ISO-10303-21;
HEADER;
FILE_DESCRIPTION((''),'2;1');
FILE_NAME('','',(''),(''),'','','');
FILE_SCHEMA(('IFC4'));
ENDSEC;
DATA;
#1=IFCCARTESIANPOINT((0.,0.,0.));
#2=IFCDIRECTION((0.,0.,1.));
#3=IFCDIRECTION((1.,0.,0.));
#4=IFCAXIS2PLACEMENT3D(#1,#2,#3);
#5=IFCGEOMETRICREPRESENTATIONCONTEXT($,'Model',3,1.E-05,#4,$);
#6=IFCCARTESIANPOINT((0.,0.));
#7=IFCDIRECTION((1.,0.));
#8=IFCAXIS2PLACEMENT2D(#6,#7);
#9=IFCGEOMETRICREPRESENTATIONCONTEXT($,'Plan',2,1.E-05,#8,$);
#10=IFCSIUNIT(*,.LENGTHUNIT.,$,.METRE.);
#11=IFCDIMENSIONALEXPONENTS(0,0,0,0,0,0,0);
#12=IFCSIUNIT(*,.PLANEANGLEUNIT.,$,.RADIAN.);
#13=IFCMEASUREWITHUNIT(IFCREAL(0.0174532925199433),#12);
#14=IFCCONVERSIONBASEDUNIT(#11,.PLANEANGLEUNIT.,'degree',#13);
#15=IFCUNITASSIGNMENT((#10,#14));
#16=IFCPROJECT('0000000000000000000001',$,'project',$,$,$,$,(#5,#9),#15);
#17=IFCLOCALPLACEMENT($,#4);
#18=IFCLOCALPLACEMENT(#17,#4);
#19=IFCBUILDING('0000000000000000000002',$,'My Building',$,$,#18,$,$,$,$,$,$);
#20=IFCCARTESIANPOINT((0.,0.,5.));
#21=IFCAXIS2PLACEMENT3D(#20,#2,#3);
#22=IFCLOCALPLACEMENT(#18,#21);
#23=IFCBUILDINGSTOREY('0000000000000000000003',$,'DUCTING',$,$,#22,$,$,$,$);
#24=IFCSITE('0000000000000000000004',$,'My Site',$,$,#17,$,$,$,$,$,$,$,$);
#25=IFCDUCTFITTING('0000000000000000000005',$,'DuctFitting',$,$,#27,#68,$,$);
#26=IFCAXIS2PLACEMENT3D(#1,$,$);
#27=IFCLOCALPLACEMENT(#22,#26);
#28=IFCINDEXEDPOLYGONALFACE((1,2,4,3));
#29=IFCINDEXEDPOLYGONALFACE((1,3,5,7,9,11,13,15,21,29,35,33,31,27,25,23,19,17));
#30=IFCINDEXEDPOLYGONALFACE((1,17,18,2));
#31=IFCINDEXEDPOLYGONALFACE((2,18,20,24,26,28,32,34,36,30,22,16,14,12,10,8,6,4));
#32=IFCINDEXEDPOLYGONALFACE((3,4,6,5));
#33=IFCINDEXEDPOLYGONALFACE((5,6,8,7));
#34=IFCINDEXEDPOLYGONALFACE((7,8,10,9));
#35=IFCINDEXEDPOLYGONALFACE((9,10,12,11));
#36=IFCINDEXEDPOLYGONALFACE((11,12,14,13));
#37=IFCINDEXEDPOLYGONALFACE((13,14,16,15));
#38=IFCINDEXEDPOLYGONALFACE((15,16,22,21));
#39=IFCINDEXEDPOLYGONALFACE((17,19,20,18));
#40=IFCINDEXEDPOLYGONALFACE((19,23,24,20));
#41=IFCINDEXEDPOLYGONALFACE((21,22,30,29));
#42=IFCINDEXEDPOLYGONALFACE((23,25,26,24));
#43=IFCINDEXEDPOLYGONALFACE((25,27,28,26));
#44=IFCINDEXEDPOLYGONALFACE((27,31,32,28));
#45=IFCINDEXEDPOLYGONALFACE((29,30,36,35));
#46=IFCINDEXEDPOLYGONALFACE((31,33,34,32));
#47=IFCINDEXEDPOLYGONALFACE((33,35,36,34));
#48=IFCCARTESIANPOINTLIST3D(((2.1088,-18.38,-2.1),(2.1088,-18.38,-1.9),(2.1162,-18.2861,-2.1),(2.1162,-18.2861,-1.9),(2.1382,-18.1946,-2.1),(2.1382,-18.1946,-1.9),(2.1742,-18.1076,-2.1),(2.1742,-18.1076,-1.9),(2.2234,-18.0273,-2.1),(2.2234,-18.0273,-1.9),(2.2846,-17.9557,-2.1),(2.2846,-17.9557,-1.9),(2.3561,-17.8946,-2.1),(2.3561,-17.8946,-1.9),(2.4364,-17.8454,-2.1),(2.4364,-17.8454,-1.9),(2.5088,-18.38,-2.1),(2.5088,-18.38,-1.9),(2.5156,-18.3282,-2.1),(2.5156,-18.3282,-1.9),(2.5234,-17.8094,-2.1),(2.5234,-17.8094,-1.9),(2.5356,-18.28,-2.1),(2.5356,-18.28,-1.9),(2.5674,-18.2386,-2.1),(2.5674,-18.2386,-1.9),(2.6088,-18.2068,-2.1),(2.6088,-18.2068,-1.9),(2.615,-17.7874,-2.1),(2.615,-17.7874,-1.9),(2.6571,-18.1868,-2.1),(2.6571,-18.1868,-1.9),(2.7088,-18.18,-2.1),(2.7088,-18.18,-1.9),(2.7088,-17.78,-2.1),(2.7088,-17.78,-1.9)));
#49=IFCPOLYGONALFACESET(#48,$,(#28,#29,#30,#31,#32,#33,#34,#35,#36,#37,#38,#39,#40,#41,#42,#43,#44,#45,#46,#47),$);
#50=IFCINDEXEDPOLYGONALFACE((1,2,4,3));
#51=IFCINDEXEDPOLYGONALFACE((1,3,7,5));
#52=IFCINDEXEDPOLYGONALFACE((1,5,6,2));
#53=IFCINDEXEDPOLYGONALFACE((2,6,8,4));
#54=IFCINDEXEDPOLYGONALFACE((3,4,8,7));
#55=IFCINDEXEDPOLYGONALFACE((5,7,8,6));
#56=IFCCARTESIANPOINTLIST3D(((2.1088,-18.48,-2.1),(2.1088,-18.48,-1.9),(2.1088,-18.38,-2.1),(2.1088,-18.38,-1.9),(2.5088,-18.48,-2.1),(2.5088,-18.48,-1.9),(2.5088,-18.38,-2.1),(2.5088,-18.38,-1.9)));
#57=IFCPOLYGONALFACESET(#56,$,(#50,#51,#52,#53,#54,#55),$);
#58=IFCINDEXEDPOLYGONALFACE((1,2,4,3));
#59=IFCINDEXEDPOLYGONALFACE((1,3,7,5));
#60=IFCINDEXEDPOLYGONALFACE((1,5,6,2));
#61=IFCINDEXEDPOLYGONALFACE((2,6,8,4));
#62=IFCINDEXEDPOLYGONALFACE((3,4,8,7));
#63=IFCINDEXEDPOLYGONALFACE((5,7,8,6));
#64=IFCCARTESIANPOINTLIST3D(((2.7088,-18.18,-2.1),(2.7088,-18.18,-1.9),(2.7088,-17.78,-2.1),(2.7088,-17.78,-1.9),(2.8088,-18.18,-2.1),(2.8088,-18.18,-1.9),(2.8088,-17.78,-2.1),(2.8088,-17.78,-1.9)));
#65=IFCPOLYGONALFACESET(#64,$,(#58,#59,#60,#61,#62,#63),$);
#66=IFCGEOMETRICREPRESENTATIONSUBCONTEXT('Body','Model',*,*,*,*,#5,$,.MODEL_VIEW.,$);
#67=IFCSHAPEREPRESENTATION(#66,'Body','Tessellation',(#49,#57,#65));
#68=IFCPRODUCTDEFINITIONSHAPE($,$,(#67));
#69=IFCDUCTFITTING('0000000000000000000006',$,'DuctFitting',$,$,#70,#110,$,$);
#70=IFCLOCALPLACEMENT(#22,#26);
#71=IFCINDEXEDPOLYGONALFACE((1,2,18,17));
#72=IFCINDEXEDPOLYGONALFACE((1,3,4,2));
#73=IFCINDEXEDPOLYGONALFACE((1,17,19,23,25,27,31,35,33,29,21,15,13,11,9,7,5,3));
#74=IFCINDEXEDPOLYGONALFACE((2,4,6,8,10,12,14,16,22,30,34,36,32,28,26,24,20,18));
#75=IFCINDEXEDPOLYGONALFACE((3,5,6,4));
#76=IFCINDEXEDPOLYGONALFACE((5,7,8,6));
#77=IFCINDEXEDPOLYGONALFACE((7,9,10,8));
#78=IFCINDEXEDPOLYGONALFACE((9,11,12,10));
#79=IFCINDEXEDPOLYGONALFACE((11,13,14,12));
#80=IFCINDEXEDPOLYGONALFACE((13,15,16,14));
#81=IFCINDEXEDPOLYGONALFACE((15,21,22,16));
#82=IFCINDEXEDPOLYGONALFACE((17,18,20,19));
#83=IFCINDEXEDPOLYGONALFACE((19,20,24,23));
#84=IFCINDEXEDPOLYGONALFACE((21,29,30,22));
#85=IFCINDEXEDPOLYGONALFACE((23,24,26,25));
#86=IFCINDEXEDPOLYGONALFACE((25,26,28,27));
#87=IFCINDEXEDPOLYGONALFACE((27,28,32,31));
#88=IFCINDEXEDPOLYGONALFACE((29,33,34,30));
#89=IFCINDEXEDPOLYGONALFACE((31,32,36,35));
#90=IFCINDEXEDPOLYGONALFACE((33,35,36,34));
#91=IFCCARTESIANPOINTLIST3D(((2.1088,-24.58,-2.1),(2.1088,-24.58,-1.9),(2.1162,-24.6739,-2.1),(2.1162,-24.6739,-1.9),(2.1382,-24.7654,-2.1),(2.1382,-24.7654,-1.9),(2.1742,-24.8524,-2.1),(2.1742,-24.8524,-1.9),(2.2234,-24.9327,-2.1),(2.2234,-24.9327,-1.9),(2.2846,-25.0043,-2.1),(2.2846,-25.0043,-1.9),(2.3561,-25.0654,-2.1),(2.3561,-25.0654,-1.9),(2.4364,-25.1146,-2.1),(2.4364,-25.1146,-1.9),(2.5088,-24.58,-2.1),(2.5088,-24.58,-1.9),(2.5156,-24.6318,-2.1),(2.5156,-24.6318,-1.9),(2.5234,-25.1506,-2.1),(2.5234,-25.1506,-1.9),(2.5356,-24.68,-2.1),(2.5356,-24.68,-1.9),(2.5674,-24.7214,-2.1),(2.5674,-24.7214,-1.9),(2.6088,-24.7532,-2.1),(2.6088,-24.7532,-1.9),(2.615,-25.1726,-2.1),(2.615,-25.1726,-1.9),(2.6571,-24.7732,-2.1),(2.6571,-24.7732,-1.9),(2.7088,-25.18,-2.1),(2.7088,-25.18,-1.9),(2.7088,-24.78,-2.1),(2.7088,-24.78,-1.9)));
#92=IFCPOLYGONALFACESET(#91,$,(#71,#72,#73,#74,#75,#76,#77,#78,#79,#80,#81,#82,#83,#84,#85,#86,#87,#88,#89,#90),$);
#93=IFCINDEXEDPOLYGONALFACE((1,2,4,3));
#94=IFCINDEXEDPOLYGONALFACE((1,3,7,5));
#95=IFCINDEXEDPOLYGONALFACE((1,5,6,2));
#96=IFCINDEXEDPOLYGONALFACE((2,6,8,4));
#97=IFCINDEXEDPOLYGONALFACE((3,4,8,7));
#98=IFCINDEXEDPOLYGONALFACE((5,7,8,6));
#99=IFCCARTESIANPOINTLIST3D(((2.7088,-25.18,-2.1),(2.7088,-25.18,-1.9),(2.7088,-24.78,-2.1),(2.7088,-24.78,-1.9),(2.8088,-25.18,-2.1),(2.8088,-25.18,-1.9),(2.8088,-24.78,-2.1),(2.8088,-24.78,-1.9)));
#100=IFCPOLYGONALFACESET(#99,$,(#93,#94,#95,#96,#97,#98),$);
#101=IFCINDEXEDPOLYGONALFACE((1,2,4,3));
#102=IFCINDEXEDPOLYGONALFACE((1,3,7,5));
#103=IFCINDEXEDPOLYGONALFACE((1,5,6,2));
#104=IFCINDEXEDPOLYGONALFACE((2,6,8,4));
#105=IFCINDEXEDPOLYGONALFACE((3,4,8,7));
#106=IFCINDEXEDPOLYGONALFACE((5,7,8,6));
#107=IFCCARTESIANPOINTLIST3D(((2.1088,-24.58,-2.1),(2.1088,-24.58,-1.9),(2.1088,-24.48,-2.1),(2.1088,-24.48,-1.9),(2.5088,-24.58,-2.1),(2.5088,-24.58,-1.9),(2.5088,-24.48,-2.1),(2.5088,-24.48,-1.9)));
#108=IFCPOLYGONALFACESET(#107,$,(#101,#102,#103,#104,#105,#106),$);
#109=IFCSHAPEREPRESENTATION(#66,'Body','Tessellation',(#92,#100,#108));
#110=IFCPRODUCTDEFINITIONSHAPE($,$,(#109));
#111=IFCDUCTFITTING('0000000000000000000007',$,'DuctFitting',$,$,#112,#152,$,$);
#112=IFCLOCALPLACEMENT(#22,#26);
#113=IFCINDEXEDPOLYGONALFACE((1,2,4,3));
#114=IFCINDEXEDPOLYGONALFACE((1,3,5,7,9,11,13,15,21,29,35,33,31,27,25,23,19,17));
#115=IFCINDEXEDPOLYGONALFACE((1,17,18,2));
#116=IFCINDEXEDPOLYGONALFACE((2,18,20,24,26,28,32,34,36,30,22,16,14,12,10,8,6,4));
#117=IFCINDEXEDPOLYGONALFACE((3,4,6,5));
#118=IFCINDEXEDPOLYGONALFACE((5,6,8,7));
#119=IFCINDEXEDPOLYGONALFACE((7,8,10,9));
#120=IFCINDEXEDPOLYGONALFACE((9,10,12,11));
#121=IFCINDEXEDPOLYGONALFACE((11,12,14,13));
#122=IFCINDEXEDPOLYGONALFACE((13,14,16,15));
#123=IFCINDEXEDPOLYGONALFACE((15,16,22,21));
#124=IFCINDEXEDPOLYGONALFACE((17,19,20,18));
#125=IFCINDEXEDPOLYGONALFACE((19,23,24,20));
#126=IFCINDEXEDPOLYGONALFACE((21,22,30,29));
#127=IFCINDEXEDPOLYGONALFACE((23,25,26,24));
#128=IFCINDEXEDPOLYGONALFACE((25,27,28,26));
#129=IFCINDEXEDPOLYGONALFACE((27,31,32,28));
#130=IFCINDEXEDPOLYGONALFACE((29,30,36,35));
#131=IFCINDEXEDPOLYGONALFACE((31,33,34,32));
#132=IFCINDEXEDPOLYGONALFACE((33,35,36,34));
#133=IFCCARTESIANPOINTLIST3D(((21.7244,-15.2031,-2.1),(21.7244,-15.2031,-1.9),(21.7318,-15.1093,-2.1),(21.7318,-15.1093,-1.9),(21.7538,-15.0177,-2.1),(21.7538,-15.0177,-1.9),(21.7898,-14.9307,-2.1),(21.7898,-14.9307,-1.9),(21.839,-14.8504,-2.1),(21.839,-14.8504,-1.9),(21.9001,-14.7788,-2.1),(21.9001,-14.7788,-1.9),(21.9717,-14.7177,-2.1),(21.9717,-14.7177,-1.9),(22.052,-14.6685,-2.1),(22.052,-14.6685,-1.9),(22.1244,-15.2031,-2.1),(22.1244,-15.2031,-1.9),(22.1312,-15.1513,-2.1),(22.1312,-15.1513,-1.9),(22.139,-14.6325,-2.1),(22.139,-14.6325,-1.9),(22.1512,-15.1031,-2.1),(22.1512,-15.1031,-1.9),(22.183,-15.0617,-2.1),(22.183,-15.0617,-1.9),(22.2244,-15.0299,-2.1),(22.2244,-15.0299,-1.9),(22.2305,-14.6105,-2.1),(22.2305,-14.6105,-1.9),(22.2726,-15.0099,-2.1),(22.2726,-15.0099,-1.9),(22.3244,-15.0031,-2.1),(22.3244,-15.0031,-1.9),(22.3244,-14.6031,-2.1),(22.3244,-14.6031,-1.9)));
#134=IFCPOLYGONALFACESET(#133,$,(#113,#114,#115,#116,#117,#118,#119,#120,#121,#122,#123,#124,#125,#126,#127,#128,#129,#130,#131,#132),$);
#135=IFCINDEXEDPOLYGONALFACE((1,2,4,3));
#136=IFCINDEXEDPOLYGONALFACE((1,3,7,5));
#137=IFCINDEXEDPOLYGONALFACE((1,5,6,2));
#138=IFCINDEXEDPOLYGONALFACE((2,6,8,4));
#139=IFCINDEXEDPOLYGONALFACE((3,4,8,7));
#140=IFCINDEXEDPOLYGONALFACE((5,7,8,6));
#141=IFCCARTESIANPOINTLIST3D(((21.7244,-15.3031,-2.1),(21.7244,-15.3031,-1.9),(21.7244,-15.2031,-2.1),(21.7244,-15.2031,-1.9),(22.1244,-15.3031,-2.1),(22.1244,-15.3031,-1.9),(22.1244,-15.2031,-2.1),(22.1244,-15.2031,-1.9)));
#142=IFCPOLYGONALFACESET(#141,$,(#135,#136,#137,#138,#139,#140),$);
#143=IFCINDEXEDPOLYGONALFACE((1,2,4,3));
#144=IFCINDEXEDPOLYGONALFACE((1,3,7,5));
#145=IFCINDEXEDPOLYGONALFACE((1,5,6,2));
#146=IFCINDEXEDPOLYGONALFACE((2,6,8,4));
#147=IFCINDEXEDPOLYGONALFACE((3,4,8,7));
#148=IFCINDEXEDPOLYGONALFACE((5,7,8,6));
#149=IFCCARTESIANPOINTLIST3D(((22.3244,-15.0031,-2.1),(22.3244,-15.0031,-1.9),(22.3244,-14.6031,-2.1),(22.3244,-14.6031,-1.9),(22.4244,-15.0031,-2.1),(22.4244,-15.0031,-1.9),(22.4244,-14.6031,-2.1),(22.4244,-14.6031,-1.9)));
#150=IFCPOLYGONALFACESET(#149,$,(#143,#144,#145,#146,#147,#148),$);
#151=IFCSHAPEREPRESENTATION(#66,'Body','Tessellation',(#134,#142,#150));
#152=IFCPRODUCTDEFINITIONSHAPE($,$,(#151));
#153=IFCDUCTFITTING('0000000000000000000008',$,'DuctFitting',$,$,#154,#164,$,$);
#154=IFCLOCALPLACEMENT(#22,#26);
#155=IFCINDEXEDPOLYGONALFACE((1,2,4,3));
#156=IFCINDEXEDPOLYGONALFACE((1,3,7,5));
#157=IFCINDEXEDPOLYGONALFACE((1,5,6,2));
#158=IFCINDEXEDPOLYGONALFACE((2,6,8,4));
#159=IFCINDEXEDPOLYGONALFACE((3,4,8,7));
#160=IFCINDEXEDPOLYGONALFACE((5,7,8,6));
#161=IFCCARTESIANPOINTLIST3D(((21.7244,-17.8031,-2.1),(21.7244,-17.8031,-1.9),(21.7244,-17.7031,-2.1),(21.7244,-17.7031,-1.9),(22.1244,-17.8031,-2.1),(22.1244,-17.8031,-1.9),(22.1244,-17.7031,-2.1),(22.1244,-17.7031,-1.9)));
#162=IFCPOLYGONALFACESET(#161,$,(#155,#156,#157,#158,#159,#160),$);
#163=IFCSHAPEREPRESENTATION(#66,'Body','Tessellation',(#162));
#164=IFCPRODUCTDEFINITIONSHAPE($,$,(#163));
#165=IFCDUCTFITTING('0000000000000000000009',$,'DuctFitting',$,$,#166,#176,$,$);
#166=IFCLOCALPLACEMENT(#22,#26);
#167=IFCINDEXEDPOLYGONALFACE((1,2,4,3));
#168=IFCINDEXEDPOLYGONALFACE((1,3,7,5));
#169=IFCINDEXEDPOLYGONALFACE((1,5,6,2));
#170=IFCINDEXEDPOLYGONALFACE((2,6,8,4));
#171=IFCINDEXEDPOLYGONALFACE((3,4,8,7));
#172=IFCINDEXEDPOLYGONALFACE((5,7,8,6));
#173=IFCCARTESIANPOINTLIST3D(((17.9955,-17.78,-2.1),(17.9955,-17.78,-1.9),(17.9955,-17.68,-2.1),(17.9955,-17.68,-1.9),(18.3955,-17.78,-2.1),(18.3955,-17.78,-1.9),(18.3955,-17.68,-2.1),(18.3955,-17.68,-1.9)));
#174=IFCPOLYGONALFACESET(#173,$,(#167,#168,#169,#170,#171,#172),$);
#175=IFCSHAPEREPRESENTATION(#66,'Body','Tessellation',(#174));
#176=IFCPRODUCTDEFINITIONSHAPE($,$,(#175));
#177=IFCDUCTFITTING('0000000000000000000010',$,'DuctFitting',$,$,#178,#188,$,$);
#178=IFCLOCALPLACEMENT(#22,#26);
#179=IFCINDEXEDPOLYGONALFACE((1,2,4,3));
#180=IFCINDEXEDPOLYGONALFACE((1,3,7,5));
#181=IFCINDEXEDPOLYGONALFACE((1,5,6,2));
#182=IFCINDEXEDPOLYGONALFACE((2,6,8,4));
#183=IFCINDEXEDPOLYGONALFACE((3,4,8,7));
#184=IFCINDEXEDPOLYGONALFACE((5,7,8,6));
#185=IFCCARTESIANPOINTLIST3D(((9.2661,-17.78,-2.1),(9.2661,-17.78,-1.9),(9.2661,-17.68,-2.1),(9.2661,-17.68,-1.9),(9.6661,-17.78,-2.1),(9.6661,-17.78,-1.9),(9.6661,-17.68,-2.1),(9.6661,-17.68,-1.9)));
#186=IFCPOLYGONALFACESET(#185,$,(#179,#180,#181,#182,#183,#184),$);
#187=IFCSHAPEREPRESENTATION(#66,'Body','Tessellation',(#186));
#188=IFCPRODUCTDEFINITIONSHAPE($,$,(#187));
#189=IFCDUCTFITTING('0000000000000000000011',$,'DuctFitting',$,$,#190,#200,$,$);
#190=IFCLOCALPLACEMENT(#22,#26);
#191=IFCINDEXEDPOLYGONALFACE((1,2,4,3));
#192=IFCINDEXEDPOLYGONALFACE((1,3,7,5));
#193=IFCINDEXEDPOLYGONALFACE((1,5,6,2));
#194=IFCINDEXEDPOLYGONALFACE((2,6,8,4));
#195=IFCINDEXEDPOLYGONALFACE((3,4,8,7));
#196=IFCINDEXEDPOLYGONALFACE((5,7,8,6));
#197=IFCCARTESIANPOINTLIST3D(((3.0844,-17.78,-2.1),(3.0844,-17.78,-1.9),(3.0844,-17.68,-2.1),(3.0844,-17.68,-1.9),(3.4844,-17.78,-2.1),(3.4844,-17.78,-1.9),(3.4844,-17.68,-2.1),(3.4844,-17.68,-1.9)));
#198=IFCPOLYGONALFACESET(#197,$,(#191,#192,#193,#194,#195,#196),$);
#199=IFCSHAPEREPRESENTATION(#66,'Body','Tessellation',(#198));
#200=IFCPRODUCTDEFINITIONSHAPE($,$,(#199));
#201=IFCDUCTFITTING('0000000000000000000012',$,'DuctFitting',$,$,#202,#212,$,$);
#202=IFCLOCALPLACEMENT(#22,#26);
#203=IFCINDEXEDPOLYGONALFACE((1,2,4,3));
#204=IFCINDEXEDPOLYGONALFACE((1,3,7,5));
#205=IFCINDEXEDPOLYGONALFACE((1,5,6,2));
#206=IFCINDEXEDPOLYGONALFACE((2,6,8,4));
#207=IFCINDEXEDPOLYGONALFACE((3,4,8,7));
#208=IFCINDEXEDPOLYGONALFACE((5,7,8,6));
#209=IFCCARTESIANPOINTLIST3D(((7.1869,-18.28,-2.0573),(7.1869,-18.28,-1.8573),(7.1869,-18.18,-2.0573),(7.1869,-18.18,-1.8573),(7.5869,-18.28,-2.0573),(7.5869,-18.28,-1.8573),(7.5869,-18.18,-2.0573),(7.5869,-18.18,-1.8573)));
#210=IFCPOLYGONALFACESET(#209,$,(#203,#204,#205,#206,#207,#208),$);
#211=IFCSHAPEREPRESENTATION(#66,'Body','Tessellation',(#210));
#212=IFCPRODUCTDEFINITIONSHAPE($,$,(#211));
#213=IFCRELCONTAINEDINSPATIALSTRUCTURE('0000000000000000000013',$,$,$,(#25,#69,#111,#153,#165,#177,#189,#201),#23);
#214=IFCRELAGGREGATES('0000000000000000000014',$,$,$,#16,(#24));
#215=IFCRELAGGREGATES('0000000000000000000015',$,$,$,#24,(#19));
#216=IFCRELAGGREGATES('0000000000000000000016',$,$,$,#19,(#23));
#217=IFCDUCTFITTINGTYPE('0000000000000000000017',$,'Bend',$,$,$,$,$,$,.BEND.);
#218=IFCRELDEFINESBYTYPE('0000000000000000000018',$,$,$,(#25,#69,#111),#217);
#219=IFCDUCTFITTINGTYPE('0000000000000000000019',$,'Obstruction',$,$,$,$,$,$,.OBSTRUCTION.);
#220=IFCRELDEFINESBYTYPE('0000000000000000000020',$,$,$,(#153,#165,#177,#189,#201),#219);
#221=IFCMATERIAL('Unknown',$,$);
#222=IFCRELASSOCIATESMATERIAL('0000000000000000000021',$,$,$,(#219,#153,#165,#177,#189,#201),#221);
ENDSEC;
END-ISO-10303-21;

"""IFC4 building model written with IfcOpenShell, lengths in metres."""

from ifc_helpers import new_model, entity, si_unit, converted_unit, frame, origin_with_axes, origin_2d_with_axis, place, context, subcontext, project, spatial, line, arc, indexed_curve, rectangle, outline, extrude, source, transform, mapped, material, material_profile, profile_set, profile_usage, type_object, type_shapes, element, save


model = new_model("IFC4")

# Units and contexts
model_context = context("Model", 3, precision=1e-05, world=origin_with_axes())
plan_context = context("Plan", 2, precision=1e-05, world=origin_2d_with_axis())
body_context = subcontext(model_context, "Body", "Model", "MODEL_VIEW")
ifc_project = project(units=[si_unit("LENGTHUNIT", "METRE"), converted_unit("PLANEANGLEUNIT", "degree", entity("IfcReal", 0.0174532925199433), si_unit("PLANEANGLEUNIT", "RADIAN"), dimensions=[0, 0, 0, 0, 0, 0, 0])], contexts=[model_context, plan_context])

# Site, building, storey
site_placement = place(None, origin_with_axes())
site = spatial("IfcSite", under=ifc_project, at=site_placement, Name="My Site")
building_placement = place(site_placement, origin_with_axes())
building = spatial("IfcBuilding", under=site, at=building_placement, Name="My Building")
storey_placement = place(building_placement, frame((0.0, 0.0, 5.0), z_axis=(0.0, 0.0, 1.0), x_axis=(1.0, 0.0, 0.0)))
storey = spatial("IfcBuildingStorey", under=building, at=storey_placement, Name="DUCTING")

# Shared definitions
ifc_material = material(Name="Unknown")

# Duct fittings
duct_fitting_type_1 = type_object("IfcDuctFittingType", Name="Bend", PredefinedType="BEND")
shared_shape = source(origin_with_axes(), body_context, "Body", "SweptSolid", [
    extrude(outline(indexed_curve([(0.2, 0.0), (0.2586, 0.1414), (0.4, 0.2), (0.4, 0.6), (-0.0243, 0.4243), (-0.2, 0.0)], segments=[arc(1, 2, 3), line(3, 4), arc(4, 5, 6), line(6, 1)])), frame((0.0, -0.1, 0.1), z_axis=(0.0, -1.0, 0.0), x_axis=(1.0, 0.0, 0.0)), (0.0, 0.0, -1.0), 0.2),
    extrude(rectangle(XDim=0.4, YDim=0.2), origin_with_axes(), (0.0, 0.0, 1.0), 0.1),
    extrude(rectangle(XDim=0.4, YDim=0.2), frame((0.4, 0.0, 0.5), z_axis=(1.0, 0.0, 0.000001), x_axis=(-0.000001, 0.0, 1.0)), (0.0, 0.0, 1.0), 0.1),
])
type_shapes(duct_fitting_type_1, [shared_shape])
for number, where, z_axis, x_axis, name in (
    (1, (2.3088, -18.48, -2.0), (0.0, 1.0, 0.0), (1.0, 0.0, 0.0), "DuctFitting"),
    (2, (2.8088, -24.98, -2.0), (-1.0, 0.0, 0.0), (0.0, 1.0, 0.0), "DuctFitting"),
    (3, (21.9244, -15.3031, -2.0), (0.0, 1.0, 0.000001), (1.0, 0.0, 0.0), "DuctFitting"),
):
    element("IfcDuctFitting", number, at=place(storey_placement, frame(where, z_axis=z_axis, x_axis=x_axis)), inside=storey, type_object=duct_fitting_type_1, Name=name, context=body_context, shape_type="MappedRepresentation", body=[
        mapped(shared_shape, transform((0.0, 0.0, 0.0), x_axis=(1.0, 0.0, 0.0), y_axis=(0.0, 1.0, 0.0), z_axis=(0.0, 0.0, 1.0), scale=1.0)),
    ])
ifc_material_profile_1 = material_profile(ifc_material, rectangle(XDim=0.4, YDim=0.2))
ifc_profile_set_1 = profile_set([ifc_material_profile_1])
ifc_profile_usage_1 = profile_usage(ifc_profile_set_1, cardinal=5)
duct_fitting_type_2 = type_object("IfcDuctFittingType", Name="Obstruction", PredefinedType="OBSTRUCTION", material=ifc_profile_set_1)
duct_fitting_1_placement = place(storey_placement, frame((21.9244, -17.8031, -2.0), z_axis=(0.0, 1.0, 0.000001), x_axis=(-1.0, 0.0, 0.0)))
element("IfcDuctFitting", 4, at=duct_fitting_1_placement, inside=storey, type_object=duct_fitting_type_2, material=ifc_profile_usage_1, Name="DuctFitting", context=body_context, shape_type="SweptSolid", body=[
    extrude(rectangle(XDim=0.4, YDim=0.2), origin_with_axes(), (0.0, 0.0, 1.0), 0.1),
])
ifc_profile_usage_2 = profile_usage(ifc_profile_set_1, cardinal=5)
duct_fitting_2_placement = place(storey_placement, frame((18.1955, -17.78, -2.0), z_axis=(0.0, 1.0, 0.000001), x_axis=(-1.0, 0.0, 0.0)))
element("IfcDuctFitting", 5, at=duct_fitting_2_placement, inside=storey, type_object=duct_fitting_type_2, material=ifc_profile_usage_2, Name="DuctFitting", context=body_context, shape_type="SweptSolid", body=[
    extrude(rectangle(XDim=0.4, YDim=0.2), origin_with_axes(), (0.0, 0.0, 1.0), 0.1),
])
ifc_profile_usage_3 = profile_usage(ifc_profile_set_1, cardinal=5)
duct_fitting_3_placement = place(storey_placement, frame((9.4661, -17.78, -2.0), z_axis=(0.0, 1.0, 0.000001), x_axis=(-1.0, 0.0, 0.0)))
element("IfcDuctFitting", 6, at=duct_fitting_3_placement, inside=storey, type_object=duct_fitting_type_2, material=ifc_profile_usage_3, Name="DuctFitting", context=body_context, shape_type="SweptSolid", body=[
    extrude(rectangle(XDim=0.4, YDim=0.2), origin_with_axes(), (0.0, 0.0, 1.0), 0.1),
])
ifc_profile_usage_4 = profile_usage(ifc_profile_set_1, cardinal=5)
duct_fitting_4_placement = place(storey_placement, frame((3.2844, -17.78, -2.0), z_axis=(0.0, 1.0, 0.000001), x_axis=(-1.0, 0.0, 0.0)))
element("IfcDuctFitting", 7, at=duct_fitting_4_placement, inside=storey, type_object=duct_fitting_type_2, material=ifc_profile_usage_4, Name="DuctFitting", context=body_context, shape_type="SweptSolid", body=[
    extrude(rectangle(XDim=0.4, YDim=0.2), origin_with_axes(), (0.0, 0.0, 1.0), 0.1),
])
ifc_profile_usage_5 = profile_usage(ifc_profile_set_1, cardinal=5)
duct_fitting_5_placement = place(storey_placement, frame((7.3869, -18.28, -1.9573), z_axis=(0.0, 1.0, 0.000001), x_axis=(-1.0, 0.0, 0.0)))
element("IfcDuctFitting", 8, at=duct_fitting_5_placement, inside=storey, type_object=duct_fitting_type_2, material=ifc_profile_usage_5, Name="DuctFitting", context=body_context, shape_type="SweptSolid", body=[
    extrude(rectangle(XDim=0.4, YDim=0.2), origin_with_axes(), (0.0, 0.0, 1.0), 0.1),
])

save(model, "model.ifc")
